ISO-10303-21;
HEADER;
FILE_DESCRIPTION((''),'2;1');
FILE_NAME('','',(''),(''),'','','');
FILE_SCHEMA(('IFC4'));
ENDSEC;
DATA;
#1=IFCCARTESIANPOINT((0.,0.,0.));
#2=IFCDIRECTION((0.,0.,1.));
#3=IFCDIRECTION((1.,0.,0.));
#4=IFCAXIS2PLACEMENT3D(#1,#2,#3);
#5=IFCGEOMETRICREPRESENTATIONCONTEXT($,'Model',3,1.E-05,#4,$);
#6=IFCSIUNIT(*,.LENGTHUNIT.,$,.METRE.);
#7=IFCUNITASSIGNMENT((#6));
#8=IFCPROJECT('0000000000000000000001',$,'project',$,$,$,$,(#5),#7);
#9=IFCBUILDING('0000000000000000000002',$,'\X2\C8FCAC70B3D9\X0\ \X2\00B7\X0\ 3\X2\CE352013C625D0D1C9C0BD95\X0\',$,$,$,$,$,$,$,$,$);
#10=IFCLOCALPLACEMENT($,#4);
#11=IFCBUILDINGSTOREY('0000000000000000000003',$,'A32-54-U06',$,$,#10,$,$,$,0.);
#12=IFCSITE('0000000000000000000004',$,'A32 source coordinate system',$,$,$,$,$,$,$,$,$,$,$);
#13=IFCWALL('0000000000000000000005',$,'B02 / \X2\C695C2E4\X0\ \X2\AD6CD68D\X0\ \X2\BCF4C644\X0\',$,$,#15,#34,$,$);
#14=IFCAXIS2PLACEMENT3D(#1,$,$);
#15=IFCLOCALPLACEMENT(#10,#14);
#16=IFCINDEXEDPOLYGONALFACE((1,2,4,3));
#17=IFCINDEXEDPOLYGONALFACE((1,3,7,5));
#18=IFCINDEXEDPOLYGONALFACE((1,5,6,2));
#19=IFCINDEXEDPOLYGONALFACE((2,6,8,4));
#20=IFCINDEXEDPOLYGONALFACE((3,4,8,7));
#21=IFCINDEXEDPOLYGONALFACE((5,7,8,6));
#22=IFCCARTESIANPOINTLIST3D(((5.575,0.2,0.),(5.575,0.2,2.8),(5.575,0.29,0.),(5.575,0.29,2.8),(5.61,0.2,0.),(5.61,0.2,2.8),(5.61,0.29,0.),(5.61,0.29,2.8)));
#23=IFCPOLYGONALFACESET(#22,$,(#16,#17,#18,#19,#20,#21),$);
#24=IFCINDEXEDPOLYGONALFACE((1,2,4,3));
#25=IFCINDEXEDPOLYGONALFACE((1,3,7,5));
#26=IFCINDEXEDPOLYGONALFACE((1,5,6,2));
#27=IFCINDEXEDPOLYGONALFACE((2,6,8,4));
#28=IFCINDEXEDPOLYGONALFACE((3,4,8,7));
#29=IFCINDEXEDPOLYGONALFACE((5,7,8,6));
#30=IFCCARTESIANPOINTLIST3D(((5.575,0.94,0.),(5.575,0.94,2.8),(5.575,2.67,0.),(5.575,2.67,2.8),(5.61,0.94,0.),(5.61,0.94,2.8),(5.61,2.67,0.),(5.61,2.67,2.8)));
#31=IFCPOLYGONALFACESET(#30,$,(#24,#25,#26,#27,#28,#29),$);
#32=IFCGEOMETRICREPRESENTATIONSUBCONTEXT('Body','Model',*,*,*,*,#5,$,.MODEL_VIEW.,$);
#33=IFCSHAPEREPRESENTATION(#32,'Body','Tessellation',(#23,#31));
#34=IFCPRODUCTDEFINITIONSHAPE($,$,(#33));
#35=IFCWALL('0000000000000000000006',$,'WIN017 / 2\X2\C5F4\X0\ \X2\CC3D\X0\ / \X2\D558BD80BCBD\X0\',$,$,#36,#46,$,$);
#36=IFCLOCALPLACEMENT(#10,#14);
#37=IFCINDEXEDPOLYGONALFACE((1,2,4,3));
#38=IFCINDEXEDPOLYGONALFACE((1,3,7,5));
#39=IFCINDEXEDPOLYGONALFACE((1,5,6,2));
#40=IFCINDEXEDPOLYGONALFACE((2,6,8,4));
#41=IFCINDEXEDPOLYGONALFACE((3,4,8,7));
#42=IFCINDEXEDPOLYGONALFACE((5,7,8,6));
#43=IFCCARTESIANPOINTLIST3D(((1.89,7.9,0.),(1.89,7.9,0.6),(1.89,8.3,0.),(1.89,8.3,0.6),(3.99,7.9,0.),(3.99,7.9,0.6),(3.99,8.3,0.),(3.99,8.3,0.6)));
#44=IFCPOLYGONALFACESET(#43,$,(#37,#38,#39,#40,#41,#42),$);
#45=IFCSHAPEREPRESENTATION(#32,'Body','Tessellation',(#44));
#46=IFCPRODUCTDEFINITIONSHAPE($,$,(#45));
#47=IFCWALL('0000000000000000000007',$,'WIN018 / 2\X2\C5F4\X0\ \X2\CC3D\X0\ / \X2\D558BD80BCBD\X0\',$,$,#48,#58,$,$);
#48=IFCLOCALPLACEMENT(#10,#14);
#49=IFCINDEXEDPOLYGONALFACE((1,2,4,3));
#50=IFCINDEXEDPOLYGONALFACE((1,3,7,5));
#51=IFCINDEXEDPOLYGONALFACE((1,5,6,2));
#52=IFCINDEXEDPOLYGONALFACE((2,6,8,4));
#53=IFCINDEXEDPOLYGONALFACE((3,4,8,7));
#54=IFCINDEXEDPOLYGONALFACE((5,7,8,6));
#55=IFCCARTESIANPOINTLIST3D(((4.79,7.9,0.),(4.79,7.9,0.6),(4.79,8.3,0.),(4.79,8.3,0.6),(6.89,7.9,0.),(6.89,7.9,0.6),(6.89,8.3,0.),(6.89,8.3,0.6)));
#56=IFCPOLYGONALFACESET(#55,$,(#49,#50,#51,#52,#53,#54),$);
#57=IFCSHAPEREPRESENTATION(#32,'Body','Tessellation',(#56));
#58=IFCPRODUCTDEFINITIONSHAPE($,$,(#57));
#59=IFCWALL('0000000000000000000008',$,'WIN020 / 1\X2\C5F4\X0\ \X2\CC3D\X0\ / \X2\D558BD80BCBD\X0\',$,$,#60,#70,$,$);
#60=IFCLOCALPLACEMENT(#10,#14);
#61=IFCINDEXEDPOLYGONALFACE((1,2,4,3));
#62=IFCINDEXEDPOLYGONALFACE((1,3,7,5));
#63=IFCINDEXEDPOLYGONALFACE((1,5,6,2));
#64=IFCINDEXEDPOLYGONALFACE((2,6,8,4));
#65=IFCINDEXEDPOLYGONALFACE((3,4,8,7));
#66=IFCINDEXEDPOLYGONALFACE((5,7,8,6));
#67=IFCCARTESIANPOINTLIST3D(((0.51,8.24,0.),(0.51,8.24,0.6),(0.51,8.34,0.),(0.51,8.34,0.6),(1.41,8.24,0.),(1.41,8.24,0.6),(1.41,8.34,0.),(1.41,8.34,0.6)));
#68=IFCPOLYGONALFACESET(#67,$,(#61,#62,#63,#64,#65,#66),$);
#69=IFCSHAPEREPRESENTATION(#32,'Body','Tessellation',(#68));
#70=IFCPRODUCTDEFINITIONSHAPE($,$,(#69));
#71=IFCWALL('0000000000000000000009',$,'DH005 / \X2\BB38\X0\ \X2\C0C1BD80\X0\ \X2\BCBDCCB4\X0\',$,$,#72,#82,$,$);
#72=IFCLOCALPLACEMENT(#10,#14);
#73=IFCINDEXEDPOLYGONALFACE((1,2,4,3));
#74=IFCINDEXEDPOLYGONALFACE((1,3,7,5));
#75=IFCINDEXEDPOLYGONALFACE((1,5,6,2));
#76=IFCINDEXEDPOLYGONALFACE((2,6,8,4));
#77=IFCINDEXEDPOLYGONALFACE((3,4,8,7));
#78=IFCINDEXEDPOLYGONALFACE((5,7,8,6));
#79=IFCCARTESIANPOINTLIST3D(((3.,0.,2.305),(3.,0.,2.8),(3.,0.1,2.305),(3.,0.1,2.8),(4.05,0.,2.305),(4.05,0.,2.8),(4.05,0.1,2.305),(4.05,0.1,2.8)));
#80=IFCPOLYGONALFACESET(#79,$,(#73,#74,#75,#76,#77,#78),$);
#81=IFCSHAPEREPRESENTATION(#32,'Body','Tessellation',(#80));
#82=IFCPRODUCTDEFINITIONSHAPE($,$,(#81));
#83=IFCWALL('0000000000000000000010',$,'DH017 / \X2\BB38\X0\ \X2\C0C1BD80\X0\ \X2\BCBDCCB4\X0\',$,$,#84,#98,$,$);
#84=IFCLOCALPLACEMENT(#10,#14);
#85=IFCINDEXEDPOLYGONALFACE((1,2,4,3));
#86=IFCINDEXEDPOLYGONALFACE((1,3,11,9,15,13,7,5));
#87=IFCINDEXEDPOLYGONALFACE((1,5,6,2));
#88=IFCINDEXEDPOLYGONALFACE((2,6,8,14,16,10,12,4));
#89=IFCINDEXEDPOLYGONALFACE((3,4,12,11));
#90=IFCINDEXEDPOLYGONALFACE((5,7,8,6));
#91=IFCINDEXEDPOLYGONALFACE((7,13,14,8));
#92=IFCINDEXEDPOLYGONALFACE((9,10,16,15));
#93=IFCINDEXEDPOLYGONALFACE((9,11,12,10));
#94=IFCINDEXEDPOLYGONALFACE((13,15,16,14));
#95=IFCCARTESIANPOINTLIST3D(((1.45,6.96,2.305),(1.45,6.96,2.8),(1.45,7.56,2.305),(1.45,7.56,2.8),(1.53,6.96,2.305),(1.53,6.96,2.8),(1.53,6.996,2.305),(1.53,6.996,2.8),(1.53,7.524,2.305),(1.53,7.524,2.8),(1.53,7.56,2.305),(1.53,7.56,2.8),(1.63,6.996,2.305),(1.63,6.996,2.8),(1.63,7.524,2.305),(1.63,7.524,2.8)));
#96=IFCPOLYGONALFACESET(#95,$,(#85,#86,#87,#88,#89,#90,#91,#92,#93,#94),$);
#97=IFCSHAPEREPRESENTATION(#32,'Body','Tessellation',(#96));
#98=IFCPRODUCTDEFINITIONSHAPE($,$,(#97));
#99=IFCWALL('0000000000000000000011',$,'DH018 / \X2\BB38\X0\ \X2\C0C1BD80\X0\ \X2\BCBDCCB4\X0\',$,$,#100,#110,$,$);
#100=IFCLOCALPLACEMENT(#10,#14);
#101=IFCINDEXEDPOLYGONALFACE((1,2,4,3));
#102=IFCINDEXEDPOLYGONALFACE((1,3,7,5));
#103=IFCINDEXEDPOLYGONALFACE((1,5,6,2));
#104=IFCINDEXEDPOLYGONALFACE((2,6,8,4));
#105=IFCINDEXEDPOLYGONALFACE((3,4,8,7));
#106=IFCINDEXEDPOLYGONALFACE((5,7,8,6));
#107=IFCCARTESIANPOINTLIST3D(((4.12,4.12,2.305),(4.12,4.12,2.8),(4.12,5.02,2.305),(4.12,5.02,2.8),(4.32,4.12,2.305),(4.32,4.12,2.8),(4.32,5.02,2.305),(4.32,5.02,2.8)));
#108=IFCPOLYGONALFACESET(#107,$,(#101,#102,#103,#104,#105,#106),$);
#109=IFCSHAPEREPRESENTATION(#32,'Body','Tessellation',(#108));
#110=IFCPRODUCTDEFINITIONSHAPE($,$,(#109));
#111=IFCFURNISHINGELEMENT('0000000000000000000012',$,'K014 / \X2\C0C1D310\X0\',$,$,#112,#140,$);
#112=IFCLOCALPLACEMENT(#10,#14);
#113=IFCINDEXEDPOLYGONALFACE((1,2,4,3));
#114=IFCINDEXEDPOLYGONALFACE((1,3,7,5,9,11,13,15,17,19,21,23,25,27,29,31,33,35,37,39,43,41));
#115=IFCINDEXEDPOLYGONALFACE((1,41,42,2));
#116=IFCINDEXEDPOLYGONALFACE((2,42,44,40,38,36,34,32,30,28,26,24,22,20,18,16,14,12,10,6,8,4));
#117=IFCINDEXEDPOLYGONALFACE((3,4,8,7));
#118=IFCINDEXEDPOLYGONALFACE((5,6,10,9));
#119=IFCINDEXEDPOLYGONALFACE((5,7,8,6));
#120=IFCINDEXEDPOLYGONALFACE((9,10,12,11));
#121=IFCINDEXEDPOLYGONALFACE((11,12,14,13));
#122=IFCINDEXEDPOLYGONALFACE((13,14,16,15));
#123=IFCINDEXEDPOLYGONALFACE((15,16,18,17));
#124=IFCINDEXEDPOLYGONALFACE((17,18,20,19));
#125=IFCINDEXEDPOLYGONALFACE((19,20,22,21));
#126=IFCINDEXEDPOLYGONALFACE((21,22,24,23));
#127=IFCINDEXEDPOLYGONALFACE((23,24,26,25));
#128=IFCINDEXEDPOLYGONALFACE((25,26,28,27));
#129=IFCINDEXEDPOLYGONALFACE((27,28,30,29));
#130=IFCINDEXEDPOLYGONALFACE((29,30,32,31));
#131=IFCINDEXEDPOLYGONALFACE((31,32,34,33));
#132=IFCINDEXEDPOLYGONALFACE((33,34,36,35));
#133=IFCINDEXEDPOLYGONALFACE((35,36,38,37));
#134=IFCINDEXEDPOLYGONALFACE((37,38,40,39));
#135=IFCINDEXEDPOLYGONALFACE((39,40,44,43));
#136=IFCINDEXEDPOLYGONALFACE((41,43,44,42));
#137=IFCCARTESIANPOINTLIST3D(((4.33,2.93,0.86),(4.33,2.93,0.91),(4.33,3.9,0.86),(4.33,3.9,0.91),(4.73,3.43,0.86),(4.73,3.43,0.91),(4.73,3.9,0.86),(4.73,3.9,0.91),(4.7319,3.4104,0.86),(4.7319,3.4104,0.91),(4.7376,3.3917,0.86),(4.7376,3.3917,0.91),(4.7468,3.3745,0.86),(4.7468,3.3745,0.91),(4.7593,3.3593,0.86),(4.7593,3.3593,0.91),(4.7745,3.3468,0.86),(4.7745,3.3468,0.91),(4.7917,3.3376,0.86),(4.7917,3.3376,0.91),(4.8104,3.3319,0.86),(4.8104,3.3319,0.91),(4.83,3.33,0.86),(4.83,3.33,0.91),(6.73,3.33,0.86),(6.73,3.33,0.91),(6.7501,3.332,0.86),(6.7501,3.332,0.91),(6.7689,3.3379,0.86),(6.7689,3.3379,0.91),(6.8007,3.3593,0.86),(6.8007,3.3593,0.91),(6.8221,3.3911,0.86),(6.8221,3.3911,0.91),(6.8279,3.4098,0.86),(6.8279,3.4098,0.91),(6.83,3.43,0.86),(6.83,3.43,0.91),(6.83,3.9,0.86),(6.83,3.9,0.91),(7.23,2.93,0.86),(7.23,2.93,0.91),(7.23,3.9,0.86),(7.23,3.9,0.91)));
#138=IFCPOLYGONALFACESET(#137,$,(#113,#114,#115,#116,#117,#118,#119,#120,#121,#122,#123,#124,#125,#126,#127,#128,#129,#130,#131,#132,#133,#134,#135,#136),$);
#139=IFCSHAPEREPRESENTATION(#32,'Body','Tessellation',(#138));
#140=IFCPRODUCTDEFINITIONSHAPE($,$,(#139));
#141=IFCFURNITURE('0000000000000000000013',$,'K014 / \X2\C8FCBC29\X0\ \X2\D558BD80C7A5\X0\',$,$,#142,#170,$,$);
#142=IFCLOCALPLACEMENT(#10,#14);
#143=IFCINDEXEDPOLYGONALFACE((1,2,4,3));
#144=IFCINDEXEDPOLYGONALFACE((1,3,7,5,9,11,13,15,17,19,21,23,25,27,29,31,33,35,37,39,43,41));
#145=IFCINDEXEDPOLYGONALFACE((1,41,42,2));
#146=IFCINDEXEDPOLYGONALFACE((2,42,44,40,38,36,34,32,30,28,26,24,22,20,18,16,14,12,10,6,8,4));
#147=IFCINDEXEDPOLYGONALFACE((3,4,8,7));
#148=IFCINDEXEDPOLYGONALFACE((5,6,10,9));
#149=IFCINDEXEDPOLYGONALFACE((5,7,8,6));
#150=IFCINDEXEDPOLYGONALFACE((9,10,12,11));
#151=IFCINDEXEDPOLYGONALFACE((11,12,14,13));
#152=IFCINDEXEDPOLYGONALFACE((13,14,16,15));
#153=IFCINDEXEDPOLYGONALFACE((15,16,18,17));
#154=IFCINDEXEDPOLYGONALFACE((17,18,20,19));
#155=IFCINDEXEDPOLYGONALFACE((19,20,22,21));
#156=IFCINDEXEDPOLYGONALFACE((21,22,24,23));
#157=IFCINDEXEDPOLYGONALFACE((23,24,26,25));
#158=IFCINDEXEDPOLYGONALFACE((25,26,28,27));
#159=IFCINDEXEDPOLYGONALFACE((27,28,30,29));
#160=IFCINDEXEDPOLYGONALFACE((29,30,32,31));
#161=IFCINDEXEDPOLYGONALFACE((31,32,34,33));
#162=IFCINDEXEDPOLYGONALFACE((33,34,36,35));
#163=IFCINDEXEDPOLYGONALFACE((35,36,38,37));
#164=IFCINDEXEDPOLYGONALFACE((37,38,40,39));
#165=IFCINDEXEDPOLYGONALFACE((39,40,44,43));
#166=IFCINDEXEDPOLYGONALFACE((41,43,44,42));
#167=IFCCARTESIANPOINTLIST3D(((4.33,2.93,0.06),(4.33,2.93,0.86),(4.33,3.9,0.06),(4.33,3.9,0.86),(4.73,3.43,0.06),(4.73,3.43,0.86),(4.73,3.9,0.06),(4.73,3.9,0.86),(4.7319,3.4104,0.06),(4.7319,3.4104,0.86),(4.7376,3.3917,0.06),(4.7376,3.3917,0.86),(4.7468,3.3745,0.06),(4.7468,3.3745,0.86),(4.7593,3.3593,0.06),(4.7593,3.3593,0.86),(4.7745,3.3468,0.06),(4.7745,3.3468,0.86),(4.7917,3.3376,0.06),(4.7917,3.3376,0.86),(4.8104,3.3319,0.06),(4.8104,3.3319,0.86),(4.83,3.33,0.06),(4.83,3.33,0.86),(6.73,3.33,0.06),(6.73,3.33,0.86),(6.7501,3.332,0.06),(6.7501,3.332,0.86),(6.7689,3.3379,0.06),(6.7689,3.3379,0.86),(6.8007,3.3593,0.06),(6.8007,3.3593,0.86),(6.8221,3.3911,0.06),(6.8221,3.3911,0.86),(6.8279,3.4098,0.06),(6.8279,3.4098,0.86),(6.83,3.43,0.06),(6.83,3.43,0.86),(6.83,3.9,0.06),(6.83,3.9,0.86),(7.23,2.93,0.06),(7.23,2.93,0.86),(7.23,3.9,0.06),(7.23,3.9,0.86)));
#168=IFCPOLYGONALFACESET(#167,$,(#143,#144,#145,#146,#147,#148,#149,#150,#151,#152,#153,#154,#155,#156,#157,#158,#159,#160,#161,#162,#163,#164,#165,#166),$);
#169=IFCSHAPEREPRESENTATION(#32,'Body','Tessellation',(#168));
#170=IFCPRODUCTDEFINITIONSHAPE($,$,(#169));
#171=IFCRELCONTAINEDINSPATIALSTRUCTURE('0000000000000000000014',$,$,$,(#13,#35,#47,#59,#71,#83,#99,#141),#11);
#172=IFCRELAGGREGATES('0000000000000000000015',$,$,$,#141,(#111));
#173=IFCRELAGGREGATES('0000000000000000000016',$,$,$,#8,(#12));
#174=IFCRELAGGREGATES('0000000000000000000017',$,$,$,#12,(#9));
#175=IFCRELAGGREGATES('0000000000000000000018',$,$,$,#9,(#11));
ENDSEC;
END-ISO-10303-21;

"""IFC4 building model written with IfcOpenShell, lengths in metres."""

from ifc_helpers import new_model, si_unit, frame, origin, origin_with_axes, place, context, subcontext, project, spatial, polyline, outline, extrude, element, aggregate, save


model = new_model("IFC4")

# Units and contexts
model_context = context("Model", 3, precision=1e-05, world=origin_with_axes())
body_context = subcontext(model_context, "Body", "Model", "MODEL_VIEW")
ifc_project = project(units=[si_unit("LENGTHUNIT", "METRE")], contexts=[model_context])

# Site, building, storey
site = spatial("IfcSite", under=ifc_project, Name="A32 source coordinate system")
building = spatial("IfcBuilding", under=site, Name="주거동 · 3층–옥탑지붕")
storey_placement = place(None, origin_with_axes())
storey = spatial("IfcBuildingStorey", under=building, at=storey_placement, Name="A32-54-U06", Elevation=0.0)

# Walls
wall_1_placement = place(storey_placement, origin_with_axes())
element("IfcWall", 1, at=wall_1_placement, inside=storey, Name="B02 / 욕실 구획 보완", context=body_context, shape_type="SweptSolid", body=[
    extrude(outline(polyline([(5.575, 0.2), (5.575, 0.29), (5.61, 0.29), (5.61, 0.2), (5.575, 0.2)])), origin(), (0.0, 0.0, 1.0), 2.8),
    extrude(outline(polyline([(5.575, 0.94), (5.575, 2.67), (5.61, 2.67), (5.61, 0.94), (5.575, 0.94)])), origin(), (0.0, 0.0, 1.0), 2.8),
])
wall_2_placement = place(storey_placement, origin_with_axes())
element("IfcWall", 2, at=wall_2_placement, inside=storey, Name="WIN017 / 2열 창 / 하부벽", context=body_context, shape_type="SweptSolid", body=[
    extrude(outline(polyline([(3.99, 8.3), (3.99, 7.9), (1.89, 7.9), (1.89, 8.3), (3.99, 8.3)])), origin(), (0.0, 0.0, 1.0), 0.6),
])
wall_3_placement = place(storey_placement, origin_with_axes())
element("IfcWall", 3, at=wall_3_placement, inside=storey, Name="WIN018 / 2열 창 / 하부벽", context=body_context, shape_type="SweptSolid", body=[
    extrude(outline(polyline([(6.89, 8.3), (6.89, 7.9), (4.79, 7.9), (4.79, 8.3), (6.89, 8.3)])), origin(), (0.0, 0.0, 1.0), 0.6),
])
wall_4_placement = place(storey_placement, origin_with_axes())
element("IfcWall", 4, at=wall_4_placement, inside=storey, Name="WIN020 / 1열 창 / 하부벽", context=body_context, shape_type="SweptSolid", body=[
    extrude(outline(polyline([(1.41, 8.34), (1.41, 8.24), (0.51, 8.24), (0.51, 8.34), (1.41, 8.34)])), origin(), (0.0, 0.0, 1.0), 0.6),
])
wall_5_placement = place(storey_placement, origin_with_axes())
element("IfcWall", 5, at=wall_5_placement, inside=storey, Name="DH005 / 문 상부 벽체", context=body_context, shape_type="SweptSolid", body=[
    extrude(outline(polyline([(4.05, 0.0), (3.0, 0.0), (3.0, 0.1), (4.05, 0.1), (4.05, 0.0)])), frame((0.0, 0.0, 2.305)), (0.0, 0.0, 1.0), 0.495),
])
wall_6_placement = place(storey_placement, origin_with_axes())
element("IfcWall", 6, at=wall_6_placement, inside=storey, Name="DH017 / 문 상부 벽체", context=body_context, shape_type="SweptSolid", body=[
    extrude(outline(polyline([(1.63, 7.524), (1.63, 6.996), (1.53, 6.996), (1.53, 6.96), (1.45, 6.96), (1.45, 7.56), (1.53, 7.56), (1.53, 7.524), (1.63, 7.524)])), frame((0.0, 0.0, 2.305)), (0.0, 0.0, 1.0), 0.495),
])
wall_7_placement = place(storey_placement, origin_with_axes())
element("IfcWall", 7, at=wall_7_placement, inside=storey, Name="DH018 / 문 상부 벽체", context=body_context, shape_type="SweptSolid", body=[
    extrude(outline(polyline([(4.32, 4.12), (4.12, 4.12), (4.12, 5.02), (4.32, 5.02), (4.32, 4.12)])), frame((0.0, 0.0, 2.305)), (0.0, 0.0, 1.0), 0.495),
])

# Furnishing element
furniture_1_placement = place(storey_placement, origin_with_axes())
furnishing_1_placement = place(furniture_1_placement, origin_with_axes())
furnishing_1 = element("IfcFurnishingElement", 8, at=furnishing_1_placement, Name="K014 / 상판", context=body_context, shape_type="SweptSolid", body=[
    extrude(outline(polyline([(4.33, 2.93), (4.33, 3.9), (4.73, 3.9), (4.73, 3.43), (4.7319, 3.4104), (4.7376, 3.3917), (4.7468, 3.3745), (4.7593, 3.3593), (4.7745, 3.3468), (4.7917, 3.3376), (4.8104, 3.3319), (4.83, 3.33), (6.73, 3.33), (6.7501, 3.332), (6.7689, 3.3379), (6.8007, 3.3593), (6.8221, 3.3911), (6.8279, 3.4098), (6.83, 3.43), (6.83, 3.9), (7.23, 3.9), (7.23, 2.93), (4.33, 2.93)])), frame((0.0, 0.0, 0.86)), (0.0, 0.0, 1.0), 0.05),
])

# Furniture
furniture_1 = element("IfcFurniture", 9, at=furniture_1_placement, inside=storey, Name="K014 / 주방 하부장", context=body_context, shape_type="SweptSolid", body=[
    extrude(outline(polyline([(7.23, 2.93), (4.33, 2.93), (4.33, 3.9), (4.73, 3.9), (4.73, 3.43), (4.7319, 3.4104), (4.7376, 3.3917), (4.7468, 3.3745), (4.7593, 3.3593), (4.7745, 3.3468), (4.7917, 3.3376), (4.8104, 3.3319), (4.83, 3.33), (6.73, 3.33), (6.7501, 3.332), (6.7689, 3.3379), (6.8007, 3.3593), (6.8221, 3.3911), (6.8279, 3.4098), (6.83, 3.43), (6.83, 3.9), (7.23, 3.9), (7.23, 2.93)])), frame((0.0, 0.0, 0.06)), (0.0, 0.0, 1.0), 0.8),
])
aggregate(furniture_1, [furnishing_1])

save(model, "model.ifc")
